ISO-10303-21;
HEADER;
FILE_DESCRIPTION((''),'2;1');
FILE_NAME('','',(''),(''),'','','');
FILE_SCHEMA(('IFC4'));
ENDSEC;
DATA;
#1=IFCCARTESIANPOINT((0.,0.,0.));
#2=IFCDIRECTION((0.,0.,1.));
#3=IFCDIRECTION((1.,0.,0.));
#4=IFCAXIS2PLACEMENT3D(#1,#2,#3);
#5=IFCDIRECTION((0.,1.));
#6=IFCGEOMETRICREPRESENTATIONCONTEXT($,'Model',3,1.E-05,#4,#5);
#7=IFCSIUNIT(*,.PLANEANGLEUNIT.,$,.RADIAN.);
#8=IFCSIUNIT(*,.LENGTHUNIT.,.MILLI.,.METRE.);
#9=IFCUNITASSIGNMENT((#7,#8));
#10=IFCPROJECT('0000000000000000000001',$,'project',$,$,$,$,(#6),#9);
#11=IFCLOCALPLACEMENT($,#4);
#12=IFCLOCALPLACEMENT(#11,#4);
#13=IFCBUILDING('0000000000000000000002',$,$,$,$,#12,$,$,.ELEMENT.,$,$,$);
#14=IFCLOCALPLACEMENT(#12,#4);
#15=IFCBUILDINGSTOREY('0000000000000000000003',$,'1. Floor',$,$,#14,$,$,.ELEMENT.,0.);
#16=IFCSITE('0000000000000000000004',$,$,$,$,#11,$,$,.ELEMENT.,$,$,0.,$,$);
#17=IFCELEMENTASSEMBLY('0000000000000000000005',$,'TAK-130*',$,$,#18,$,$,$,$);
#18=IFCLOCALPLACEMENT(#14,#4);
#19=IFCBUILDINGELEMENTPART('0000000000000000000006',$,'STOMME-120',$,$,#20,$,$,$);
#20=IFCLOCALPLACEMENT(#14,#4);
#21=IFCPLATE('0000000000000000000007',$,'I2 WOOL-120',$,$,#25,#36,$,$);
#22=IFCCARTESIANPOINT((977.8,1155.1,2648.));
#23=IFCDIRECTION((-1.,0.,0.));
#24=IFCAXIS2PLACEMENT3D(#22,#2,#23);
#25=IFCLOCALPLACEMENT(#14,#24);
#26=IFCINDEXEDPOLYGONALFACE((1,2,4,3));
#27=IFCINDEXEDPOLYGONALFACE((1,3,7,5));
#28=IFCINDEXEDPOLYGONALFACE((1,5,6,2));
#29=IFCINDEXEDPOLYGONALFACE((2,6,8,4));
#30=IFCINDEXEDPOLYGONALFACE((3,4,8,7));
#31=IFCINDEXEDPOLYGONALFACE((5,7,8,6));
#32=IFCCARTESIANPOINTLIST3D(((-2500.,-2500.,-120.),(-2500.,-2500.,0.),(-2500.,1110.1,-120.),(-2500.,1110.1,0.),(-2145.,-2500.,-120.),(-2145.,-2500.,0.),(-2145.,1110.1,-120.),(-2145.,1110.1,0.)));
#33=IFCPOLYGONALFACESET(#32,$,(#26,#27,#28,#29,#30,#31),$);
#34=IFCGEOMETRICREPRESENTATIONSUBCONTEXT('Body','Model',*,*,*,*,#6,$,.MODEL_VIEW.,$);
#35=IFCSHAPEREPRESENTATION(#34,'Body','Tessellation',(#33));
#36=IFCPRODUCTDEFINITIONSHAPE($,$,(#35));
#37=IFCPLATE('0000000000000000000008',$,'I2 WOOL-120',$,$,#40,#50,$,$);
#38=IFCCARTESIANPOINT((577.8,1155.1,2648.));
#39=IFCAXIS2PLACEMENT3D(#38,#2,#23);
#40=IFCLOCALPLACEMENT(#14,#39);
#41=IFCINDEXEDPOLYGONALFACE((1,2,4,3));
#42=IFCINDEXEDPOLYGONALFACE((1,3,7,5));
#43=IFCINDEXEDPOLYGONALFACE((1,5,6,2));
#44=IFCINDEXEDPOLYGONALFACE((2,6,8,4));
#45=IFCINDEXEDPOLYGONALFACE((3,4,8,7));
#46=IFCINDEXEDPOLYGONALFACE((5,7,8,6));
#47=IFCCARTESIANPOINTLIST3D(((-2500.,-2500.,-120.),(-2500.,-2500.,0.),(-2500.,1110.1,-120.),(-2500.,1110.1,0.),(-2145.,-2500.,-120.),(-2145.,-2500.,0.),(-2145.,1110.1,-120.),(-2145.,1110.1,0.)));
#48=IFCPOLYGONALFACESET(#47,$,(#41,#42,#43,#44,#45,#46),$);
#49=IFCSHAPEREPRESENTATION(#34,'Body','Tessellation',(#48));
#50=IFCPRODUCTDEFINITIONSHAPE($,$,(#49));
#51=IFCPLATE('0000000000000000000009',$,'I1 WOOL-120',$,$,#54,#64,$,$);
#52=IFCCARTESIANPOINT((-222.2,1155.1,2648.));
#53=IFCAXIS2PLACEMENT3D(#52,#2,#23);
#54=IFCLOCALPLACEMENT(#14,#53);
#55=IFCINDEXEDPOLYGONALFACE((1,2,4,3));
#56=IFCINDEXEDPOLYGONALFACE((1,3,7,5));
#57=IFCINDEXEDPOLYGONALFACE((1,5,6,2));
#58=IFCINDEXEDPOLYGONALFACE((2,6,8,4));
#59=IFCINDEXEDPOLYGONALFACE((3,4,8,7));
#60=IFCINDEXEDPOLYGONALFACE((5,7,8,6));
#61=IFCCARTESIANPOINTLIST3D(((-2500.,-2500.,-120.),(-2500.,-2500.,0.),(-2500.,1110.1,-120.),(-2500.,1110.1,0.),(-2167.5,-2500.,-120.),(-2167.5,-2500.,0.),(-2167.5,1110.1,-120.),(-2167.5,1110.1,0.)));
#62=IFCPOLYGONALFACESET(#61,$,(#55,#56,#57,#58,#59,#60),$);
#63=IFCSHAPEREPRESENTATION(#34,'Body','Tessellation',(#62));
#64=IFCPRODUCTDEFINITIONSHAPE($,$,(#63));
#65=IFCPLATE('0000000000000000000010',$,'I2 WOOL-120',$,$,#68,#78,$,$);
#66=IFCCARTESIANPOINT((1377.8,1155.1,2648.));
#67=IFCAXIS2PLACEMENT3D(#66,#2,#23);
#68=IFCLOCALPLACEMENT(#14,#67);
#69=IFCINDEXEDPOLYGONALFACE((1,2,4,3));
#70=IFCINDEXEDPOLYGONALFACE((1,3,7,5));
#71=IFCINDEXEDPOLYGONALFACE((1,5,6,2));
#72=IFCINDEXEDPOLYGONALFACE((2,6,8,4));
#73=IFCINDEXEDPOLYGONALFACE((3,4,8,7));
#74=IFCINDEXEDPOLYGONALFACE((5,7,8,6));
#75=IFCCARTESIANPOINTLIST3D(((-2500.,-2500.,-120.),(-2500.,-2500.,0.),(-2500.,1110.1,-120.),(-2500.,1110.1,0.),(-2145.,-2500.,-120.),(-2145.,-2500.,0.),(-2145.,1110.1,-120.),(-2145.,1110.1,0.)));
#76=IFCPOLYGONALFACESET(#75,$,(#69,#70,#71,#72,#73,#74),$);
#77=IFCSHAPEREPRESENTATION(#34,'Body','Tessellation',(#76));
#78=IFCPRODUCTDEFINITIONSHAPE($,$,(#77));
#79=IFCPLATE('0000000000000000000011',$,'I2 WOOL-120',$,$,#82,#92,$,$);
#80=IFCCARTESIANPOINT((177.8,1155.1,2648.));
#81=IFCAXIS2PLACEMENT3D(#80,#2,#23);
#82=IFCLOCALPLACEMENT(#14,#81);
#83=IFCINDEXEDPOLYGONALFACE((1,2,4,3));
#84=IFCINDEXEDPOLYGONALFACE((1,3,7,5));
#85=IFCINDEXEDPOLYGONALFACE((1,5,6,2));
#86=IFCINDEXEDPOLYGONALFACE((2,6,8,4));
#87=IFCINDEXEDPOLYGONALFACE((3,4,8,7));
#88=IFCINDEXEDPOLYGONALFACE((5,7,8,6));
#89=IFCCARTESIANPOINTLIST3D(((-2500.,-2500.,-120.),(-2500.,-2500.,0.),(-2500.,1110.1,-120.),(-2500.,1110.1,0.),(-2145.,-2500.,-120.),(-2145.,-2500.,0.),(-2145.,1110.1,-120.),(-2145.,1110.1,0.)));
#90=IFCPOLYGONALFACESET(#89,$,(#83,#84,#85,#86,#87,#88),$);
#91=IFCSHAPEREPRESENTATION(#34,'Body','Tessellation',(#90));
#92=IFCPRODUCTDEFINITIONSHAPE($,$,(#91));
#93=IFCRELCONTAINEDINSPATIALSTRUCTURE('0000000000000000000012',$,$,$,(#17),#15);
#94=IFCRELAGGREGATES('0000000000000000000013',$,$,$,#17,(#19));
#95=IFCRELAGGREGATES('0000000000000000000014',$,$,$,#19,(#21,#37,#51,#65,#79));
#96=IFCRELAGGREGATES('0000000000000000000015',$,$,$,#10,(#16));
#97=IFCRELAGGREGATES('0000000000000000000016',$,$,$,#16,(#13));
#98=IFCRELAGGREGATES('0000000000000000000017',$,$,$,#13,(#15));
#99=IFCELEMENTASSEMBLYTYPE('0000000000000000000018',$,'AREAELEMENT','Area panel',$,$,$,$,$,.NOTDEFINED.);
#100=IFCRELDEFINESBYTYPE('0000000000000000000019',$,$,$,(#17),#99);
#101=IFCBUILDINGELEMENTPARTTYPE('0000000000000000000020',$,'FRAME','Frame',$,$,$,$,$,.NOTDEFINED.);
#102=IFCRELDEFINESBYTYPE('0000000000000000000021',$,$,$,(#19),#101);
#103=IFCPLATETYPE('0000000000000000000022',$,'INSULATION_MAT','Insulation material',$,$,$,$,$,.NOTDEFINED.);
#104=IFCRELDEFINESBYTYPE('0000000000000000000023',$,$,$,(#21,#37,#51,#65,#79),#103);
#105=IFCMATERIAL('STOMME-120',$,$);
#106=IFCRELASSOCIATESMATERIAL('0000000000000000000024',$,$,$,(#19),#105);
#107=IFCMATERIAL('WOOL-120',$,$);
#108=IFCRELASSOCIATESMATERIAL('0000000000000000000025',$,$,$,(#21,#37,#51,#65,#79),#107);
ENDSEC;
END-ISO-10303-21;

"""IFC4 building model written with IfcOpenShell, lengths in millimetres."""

from ifc_helpers import new_model, si_unit, direction, frame, origin_with_axes, origin_2d_with_axis, place, context, subcontext, project, spatial, rectangle, extrude, material, type_object, element, aggregate, save


model = new_model("IFC4")

# Units and contexts
model_context = context("Model", 3, precision=1e-05, world=origin_with_axes(), true_north=direction((0.0, 1.0)))
body_context = subcontext(model_context, "Body", "Model", "MODEL_VIEW")
ifc_project = project(units=[si_unit("PLANEANGLEUNIT", "RADIAN"), si_unit("LENGTHUNIT", "METRE", prefix="MILLI")], contexts=[model_context])

# Site, building, storey
site_placement = place(None, origin_with_axes())
site = spatial("IfcSite", under=ifc_project, at=site_placement, CompositionType="ELEMENT", RefElevation=0.0)
building_placement = place(site_placement, origin_with_axes())
building = spatial("IfcBuilding", under=site, at=building_placement, CompositionType="ELEMENT")
storey_placement = place(building_placement, origin_with_axes())
storey = spatial("IfcBuildingStorey", under=building, at=storey_placement, Name="1. Floor", CompositionType="ELEMENT", Elevation=0.0)

# Shared definitions
building_element_part_type_1 = type_object("IfcBuildingElementPartType", Name="FRAME", Description="Frame", PredefinedType="NOTDEFINED")

# Element assembly, building element part, plates
element_assembly_type_1 = type_object("IfcElementAssemblyType", Name="AREAELEMENT", Description="Area panel", PredefinedType="NOTDEFINED")
assembly_1_placement = place(storey_placement, origin_with_axes())
assembly_1 = element("IfcElementAssembly", 1, at=assembly_1_placement, inside=storey, type_object=element_assembly_type_1, Name="TAK-130*")
ifc_material_1 = material(Name="STOMME-120")
building_element_part_1_placement = place(storey_placement, origin_with_axes())
building_element_part_1 = element("IfcBuildingElementPart", 2, at=building_element_part_1_placement, type_object=building_element_part_type_1, material=ifc_material_1, Name="STOMME-120")
aggregate(assembly_1, [building_element_part_1])
ifc_material_2 = material(Name="WOOL-120")
plate_type = type_object("IfcPlateType", Name="INSULATION_MAT", Description="Insulation material", PredefinedType="NOTDEFINED")
plate_1_placement = place(storey_placement, frame((977.8, 1155.1, 2648.0), z_axis=(0.0, 0.0, 1.0), x_axis=(-1.0, 0.0, 0.0)))
plate_1 = element("IfcPlate", 3, at=plate_1_placement, type_object=plate_type, material=ifc_material_2, Name="I2 WOOL-120", context=body_context, shape_type="SweptSolid", body=[
    extrude(rectangle(XDim=120.0, YDim=355.0, at=origin_2d_with_axis()), frame((-2322.5, -2500.0, -60.0), z_axis=(0.0, 1.0, 0.0), x_axis=(0.0, 0.0, 1.0)), (0.0, 0.0, 1.0), 3610.1),
])
plate_2_placement = place(storey_placement, frame((577.8, 1155.1, 2648.0), z_axis=(0.0, 0.0, 1.0), x_axis=(-1.0, 0.0, 0.0)))
plate_2 = element("IfcPlate", 4, at=plate_2_placement, type_object=plate_type, material=ifc_material_2, Name="I2 WOOL-120", context=body_context, shape_type="SweptSolid", body=[
    extrude(rectangle(XDim=120.0, YDim=355.0, at=origin_2d_with_axis()), frame((-2322.5, -2500.0, -60.0), z_axis=(0.0, 1.0, 0.0), x_axis=(0.0, 0.0, 1.0)), (0.0, 0.0, 1.0), 3610.1),
])
plate_3_placement = place(storey_placement, frame((-222.2, 1155.1, 2648.0), z_axis=(0.0, 0.0, 1.0), x_axis=(-1.0, 0.0, 0.0)))
plate_3 = element("IfcPlate", 5, at=plate_3_placement, type_object=plate_type, material=ifc_material_2, Name="I1 WOOL-120", context=body_context, shape_type="SweptSolid", body=[
    extrude(rectangle(XDim=120.0, YDim=332.5, at=origin_2d_with_axis()), frame((-2333.8, -2500.0, -60.0), z_axis=(0.0, 1.0, 0.0), x_axis=(0.0, 0.0, 1.0)), (0.0, 0.0, 1.0), 3610.1),
])
plate_4_placement = place(storey_placement, frame((1377.8, 1155.1, 2648.0), z_axis=(0.0, 0.0, 1.0), x_axis=(-1.0, 0.0, 0.0)))
plate_4 = element("IfcPlate", 6, at=plate_4_placement, type_object=plate_type, material=ifc_material_2, Name="I2 WOOL-120", context=body_context, shape_type="SweptSolid", body=[
    extrude(rectangle(XDim=120.0, YDim=355.0, at=origin_2d_with_axis()), frame((-2322.5, -2500.0, -60.0), z_axis=(0.0, 1.0, 0.0), x_axis=(0.0, 0.0, 1.0)), (0.0, 0.0, 1.0), 3610.1),
])
plate_5_placement = place(storey_placement, frame((177.8, 1155.1, 2648.0), z_axis=(0.0, 0.0, 1.0), x_axis=(-1.0, 0.0, 0.0)))
plate_5 = element("IfcPlate", 7, at=plate_5_placement, type_object=plate_type, material=ifc_material_2, Name="I2 WOOL-120", context=body_context, shape_type="SweptSolid", body=[
    extrude(rectangle(XDim=120.0, YDim=355.0, at=origin_2d_with_axis()), frame((-2322.5, -2500.0, -60.0), z_axis=(0.0, 1.0, 0.0), x_axis=(0.0, 0.0, 1.0)), (0.0, 0.0, 1.0), 3610.1),
])
aggregate(building_element_part_1, [plate_1, plate_2, plate_3, plate_4, plate_5])

save(model, "model.ifc")
